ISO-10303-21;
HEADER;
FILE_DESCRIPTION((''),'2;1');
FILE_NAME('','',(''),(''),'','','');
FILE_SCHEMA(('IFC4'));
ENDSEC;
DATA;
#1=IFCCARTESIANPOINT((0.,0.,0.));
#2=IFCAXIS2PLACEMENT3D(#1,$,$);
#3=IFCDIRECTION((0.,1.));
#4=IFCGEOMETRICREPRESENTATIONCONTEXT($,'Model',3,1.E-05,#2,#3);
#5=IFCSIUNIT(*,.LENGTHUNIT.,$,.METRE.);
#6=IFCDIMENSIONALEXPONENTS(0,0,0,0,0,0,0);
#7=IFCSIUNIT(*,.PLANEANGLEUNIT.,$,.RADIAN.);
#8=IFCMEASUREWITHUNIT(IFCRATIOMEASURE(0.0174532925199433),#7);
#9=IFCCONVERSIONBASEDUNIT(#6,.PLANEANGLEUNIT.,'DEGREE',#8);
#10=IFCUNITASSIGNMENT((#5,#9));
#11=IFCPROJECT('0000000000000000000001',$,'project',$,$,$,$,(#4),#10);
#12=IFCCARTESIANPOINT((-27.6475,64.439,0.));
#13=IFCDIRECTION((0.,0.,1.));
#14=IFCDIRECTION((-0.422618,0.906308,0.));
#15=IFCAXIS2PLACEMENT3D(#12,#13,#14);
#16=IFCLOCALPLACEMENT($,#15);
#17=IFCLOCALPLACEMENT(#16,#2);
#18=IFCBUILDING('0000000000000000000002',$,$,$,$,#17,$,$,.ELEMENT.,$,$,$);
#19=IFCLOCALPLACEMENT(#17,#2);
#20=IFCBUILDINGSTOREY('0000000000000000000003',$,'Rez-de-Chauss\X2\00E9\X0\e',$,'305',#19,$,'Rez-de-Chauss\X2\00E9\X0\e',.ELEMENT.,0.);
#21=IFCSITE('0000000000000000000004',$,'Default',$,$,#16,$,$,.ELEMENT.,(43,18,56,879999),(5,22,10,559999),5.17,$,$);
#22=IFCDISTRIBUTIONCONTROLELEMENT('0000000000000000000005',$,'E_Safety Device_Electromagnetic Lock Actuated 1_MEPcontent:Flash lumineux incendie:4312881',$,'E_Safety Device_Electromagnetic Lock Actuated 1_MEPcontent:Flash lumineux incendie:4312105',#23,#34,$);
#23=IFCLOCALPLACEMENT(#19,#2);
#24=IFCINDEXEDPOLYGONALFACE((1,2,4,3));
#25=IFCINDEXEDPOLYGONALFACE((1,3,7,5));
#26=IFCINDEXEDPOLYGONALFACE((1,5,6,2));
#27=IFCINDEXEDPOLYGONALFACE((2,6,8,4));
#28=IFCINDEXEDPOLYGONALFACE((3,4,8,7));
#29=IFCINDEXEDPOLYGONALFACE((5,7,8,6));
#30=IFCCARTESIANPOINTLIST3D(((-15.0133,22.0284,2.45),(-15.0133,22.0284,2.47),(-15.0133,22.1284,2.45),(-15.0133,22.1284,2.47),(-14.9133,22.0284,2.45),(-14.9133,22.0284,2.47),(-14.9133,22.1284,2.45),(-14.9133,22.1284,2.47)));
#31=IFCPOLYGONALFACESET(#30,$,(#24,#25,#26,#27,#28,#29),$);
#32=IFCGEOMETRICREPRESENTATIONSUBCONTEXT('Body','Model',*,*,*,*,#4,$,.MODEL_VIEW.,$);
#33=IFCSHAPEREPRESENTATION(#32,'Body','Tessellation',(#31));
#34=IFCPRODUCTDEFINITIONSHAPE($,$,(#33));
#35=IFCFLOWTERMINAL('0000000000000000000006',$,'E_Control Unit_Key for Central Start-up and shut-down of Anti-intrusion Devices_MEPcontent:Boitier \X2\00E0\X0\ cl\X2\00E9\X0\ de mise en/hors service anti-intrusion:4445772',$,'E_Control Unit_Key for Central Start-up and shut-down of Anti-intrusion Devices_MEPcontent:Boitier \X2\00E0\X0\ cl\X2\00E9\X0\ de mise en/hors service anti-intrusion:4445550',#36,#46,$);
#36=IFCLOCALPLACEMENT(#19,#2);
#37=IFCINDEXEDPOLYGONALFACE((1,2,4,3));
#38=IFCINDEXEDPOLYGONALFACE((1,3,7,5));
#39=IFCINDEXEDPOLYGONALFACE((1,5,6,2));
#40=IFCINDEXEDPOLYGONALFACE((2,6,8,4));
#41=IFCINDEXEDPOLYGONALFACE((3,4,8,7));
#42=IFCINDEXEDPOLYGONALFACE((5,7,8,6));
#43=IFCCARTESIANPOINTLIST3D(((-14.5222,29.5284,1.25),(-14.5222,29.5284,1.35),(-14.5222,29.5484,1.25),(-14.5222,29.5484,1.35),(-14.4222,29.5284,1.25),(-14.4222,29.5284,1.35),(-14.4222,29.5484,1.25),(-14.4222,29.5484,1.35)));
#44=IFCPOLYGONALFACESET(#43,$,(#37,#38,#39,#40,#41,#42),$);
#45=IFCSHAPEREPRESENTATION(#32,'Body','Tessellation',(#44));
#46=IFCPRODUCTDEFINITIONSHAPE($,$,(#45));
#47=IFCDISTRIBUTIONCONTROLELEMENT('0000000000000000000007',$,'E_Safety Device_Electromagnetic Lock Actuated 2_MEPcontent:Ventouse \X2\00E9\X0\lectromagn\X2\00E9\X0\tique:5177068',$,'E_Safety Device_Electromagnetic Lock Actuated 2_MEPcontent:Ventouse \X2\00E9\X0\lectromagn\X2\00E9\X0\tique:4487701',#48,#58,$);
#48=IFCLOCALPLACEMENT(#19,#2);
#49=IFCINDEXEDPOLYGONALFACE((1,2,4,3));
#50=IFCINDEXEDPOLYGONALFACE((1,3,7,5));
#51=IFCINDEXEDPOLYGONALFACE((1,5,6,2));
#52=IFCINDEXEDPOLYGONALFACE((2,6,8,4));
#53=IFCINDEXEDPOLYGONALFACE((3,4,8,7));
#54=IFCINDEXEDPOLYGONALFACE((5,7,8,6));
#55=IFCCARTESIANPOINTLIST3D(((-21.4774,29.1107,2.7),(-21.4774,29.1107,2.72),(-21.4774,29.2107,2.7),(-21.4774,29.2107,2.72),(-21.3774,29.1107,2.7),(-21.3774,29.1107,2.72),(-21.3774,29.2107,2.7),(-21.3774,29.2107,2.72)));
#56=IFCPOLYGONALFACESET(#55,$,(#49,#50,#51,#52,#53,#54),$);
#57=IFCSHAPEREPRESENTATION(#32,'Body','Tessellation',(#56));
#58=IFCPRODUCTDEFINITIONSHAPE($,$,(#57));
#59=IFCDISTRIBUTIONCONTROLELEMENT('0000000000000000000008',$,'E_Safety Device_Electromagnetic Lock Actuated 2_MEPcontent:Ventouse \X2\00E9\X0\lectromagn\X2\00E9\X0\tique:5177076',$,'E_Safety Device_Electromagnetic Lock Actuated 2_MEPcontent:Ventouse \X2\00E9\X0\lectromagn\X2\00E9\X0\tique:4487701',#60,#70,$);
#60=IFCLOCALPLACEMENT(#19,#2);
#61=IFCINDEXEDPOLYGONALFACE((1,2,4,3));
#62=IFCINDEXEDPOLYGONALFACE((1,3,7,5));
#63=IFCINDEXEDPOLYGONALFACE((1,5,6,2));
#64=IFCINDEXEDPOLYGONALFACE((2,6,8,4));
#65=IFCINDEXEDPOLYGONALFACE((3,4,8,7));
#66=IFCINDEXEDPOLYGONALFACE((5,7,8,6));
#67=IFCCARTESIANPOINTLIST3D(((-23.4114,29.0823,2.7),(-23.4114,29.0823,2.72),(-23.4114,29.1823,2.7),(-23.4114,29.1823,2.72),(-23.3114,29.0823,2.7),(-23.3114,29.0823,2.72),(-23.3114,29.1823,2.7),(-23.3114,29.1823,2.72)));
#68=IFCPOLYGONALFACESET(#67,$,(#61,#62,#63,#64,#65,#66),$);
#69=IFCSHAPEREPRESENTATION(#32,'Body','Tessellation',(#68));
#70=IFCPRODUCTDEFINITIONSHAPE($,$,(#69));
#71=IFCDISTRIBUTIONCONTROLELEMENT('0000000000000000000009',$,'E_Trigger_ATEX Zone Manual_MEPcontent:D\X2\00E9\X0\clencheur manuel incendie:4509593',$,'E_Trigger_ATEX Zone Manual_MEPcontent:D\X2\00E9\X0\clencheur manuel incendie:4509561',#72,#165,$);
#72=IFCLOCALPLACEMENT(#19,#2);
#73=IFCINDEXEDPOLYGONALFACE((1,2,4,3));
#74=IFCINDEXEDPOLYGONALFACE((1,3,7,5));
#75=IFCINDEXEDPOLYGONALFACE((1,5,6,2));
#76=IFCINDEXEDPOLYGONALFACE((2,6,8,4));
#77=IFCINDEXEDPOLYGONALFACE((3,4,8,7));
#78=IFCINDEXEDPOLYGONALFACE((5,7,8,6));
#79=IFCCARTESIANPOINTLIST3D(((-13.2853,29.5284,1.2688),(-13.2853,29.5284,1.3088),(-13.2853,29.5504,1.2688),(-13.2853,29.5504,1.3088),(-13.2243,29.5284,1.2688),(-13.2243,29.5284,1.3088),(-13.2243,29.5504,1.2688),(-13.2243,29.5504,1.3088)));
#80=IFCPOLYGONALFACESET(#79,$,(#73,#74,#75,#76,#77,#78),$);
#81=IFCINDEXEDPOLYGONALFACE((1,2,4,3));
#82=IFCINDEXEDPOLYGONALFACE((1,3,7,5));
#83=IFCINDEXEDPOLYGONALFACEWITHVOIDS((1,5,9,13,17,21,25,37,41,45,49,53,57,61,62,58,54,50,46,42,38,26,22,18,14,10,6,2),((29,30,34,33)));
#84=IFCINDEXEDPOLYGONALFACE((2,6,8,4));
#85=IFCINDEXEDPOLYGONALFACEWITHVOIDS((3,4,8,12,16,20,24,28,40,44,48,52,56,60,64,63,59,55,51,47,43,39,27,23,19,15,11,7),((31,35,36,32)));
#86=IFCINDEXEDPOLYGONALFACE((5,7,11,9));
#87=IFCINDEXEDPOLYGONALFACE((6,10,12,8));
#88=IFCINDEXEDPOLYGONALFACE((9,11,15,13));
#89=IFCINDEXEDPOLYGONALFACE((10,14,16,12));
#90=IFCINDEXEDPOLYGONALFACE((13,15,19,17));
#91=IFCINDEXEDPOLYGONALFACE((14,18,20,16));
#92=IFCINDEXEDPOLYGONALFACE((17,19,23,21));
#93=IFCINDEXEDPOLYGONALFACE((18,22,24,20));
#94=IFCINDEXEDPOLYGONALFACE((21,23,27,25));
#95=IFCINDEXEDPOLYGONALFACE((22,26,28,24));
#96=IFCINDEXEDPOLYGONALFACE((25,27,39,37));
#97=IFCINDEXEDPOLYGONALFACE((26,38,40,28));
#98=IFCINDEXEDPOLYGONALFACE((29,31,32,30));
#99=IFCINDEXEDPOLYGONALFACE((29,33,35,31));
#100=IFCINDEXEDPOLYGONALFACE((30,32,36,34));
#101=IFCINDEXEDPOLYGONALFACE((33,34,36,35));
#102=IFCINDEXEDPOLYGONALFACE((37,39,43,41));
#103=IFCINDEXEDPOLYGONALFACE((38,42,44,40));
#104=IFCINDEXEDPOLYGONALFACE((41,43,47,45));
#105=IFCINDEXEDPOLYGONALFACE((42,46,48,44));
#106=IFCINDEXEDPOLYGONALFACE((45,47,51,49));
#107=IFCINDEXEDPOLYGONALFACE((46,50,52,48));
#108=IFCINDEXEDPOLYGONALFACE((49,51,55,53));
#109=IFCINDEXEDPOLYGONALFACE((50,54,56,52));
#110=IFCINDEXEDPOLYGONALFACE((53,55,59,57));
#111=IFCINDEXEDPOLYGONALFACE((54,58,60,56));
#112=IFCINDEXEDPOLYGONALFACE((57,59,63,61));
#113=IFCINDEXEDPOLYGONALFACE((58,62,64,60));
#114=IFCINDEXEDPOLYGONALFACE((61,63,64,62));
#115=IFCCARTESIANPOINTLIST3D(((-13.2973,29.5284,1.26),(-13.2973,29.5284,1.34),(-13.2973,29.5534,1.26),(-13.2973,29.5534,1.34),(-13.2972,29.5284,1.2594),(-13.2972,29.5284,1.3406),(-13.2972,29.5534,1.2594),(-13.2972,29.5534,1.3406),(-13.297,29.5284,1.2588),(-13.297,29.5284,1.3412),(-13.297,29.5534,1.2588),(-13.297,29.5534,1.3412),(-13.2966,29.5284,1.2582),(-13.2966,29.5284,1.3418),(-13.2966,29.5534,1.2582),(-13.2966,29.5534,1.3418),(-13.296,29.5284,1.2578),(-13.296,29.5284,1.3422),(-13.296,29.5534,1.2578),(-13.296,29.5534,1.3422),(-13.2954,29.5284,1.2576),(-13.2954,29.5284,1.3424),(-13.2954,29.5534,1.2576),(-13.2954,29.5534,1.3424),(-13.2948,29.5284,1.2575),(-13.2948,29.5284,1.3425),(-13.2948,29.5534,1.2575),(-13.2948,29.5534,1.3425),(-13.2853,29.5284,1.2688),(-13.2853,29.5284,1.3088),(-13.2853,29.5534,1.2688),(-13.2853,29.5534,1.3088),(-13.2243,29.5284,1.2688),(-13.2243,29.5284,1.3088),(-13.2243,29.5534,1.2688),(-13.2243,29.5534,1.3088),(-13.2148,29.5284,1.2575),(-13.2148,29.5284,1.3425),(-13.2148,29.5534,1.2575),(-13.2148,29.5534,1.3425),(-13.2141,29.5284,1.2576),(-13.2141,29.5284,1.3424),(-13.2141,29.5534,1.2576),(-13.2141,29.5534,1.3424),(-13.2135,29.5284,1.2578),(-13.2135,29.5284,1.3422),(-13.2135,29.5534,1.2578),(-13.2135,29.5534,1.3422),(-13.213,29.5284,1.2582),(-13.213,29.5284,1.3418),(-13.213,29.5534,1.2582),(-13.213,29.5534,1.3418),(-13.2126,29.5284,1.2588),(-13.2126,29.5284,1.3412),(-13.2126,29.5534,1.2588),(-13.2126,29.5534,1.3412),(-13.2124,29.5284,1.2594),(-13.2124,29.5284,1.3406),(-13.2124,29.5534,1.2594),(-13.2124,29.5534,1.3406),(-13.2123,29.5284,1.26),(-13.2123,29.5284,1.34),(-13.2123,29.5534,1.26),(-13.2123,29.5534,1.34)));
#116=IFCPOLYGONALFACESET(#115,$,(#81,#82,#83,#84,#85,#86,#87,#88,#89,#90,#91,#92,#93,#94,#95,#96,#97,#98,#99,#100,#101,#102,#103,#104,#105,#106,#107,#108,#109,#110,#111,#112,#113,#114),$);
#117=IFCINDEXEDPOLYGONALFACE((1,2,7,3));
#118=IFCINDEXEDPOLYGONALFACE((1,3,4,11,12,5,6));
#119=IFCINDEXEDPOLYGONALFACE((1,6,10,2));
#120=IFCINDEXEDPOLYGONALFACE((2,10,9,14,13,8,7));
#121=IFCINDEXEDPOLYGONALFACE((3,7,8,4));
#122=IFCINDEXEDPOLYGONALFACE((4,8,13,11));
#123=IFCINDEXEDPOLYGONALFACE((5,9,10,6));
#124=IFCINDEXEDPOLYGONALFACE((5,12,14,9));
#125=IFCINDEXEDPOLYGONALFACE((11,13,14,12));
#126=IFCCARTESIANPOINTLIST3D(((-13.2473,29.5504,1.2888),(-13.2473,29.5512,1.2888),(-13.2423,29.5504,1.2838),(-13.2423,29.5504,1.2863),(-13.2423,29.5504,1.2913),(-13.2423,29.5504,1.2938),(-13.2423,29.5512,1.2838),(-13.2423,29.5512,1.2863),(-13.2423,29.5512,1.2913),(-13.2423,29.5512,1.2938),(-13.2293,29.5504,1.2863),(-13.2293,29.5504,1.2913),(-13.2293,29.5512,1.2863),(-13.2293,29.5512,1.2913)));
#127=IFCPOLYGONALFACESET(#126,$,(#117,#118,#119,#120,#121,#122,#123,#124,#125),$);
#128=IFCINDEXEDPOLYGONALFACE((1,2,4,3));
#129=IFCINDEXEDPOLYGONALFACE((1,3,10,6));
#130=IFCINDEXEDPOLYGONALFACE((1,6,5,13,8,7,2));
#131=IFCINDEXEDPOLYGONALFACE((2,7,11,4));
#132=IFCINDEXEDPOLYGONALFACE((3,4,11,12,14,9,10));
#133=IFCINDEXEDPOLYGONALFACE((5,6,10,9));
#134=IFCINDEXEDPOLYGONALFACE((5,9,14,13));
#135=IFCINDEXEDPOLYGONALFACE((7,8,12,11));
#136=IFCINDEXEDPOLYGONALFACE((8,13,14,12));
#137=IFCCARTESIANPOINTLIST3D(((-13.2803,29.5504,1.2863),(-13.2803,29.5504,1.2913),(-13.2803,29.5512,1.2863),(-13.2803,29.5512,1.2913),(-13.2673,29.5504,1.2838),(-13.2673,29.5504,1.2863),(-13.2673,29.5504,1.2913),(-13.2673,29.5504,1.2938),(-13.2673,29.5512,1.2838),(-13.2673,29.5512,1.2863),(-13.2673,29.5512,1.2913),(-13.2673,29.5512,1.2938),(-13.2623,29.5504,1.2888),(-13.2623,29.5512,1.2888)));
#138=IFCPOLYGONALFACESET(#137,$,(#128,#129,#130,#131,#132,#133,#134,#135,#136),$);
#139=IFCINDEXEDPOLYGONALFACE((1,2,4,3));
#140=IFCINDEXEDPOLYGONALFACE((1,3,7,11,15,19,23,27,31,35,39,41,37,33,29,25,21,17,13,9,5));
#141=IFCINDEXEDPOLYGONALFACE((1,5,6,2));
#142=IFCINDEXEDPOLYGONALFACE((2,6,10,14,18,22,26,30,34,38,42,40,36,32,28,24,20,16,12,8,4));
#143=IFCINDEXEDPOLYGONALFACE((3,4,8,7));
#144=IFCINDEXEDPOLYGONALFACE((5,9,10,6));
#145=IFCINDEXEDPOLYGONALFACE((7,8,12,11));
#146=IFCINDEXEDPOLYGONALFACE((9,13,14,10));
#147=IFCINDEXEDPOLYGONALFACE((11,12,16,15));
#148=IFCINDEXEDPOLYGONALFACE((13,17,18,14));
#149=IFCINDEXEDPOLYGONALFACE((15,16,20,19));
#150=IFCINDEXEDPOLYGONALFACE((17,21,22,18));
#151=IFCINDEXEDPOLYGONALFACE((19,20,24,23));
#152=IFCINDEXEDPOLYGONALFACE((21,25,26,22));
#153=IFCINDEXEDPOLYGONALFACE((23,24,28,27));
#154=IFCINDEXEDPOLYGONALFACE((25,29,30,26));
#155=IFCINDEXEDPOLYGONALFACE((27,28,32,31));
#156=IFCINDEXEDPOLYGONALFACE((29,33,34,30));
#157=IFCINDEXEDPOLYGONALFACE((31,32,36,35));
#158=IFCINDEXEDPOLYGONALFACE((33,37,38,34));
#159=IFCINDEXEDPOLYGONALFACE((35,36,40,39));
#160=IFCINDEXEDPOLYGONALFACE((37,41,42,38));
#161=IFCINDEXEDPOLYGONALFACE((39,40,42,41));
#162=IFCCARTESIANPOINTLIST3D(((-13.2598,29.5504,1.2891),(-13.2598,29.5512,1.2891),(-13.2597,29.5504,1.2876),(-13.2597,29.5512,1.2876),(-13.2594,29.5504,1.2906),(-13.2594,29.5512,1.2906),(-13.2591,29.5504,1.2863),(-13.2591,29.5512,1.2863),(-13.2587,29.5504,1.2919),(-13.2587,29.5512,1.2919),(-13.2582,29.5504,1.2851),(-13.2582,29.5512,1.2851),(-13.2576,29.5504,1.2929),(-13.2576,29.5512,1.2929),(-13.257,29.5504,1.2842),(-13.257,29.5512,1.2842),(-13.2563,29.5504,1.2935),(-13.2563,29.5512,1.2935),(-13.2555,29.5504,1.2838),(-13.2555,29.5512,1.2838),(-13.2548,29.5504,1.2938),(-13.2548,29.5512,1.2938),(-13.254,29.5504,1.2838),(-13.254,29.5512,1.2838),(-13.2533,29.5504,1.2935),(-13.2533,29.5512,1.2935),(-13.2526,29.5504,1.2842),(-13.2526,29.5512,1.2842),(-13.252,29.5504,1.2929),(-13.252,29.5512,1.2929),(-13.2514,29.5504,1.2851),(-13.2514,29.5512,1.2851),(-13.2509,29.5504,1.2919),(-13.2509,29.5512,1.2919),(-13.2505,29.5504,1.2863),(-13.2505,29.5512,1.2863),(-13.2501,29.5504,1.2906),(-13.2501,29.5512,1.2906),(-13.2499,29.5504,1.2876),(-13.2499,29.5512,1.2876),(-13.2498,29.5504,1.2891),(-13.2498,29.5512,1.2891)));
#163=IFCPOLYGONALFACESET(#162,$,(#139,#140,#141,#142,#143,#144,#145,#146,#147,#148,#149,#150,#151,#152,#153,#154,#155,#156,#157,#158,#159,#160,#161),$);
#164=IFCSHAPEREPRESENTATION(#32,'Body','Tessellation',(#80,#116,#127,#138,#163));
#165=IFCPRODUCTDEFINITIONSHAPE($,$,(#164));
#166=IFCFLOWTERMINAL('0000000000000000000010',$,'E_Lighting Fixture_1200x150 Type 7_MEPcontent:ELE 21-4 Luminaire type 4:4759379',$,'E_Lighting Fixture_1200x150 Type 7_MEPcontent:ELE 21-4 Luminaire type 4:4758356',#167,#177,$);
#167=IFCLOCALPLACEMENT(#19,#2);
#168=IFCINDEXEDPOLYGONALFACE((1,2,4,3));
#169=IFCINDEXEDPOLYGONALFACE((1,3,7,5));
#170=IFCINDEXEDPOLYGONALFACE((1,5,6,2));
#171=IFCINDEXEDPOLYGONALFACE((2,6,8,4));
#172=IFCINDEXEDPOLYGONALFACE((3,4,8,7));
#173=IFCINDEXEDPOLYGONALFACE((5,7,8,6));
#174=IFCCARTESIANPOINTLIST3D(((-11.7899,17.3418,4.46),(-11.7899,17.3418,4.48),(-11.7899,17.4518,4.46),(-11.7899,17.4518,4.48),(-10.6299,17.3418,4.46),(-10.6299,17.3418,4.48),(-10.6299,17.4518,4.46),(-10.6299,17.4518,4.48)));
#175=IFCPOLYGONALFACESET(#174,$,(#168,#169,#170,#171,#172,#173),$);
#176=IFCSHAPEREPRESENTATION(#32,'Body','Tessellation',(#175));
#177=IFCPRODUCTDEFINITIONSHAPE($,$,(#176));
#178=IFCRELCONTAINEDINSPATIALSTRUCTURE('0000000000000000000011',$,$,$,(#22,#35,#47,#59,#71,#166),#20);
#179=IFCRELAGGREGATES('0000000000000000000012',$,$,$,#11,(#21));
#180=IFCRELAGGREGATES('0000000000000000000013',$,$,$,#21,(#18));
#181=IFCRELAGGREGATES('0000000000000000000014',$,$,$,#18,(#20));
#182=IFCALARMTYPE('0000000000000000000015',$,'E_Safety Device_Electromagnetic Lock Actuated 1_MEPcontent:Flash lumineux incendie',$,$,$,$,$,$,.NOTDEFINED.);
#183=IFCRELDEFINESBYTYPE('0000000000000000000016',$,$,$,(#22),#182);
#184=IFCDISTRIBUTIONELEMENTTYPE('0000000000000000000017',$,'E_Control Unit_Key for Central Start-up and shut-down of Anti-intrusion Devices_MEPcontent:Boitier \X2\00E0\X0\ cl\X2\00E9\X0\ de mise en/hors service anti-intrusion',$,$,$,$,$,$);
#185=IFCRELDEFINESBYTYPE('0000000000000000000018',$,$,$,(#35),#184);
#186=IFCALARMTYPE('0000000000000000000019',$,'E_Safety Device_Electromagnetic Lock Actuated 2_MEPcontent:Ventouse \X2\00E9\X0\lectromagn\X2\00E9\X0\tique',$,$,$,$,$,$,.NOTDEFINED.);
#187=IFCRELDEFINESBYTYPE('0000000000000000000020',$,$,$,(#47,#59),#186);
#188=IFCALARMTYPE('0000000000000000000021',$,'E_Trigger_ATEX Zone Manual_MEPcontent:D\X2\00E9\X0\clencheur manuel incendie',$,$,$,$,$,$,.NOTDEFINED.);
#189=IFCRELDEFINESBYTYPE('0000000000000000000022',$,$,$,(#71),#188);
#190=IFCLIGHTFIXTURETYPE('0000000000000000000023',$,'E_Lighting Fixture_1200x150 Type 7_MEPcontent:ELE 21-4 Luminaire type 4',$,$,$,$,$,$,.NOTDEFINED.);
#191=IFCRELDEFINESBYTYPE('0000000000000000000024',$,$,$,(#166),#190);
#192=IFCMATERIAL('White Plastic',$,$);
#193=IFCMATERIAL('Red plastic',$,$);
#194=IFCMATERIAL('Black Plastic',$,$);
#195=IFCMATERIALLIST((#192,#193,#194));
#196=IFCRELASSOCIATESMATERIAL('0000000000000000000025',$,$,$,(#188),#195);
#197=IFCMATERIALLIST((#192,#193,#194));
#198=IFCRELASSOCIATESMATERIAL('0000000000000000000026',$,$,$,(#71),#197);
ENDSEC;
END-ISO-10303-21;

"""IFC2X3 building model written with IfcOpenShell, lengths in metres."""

from ifc_helpers import new_model, entity, si_unit, converted_unit, direction, frame, frame_2d, origin, origin_2d_with_axis, place, context, subcontext, project, spatial, polyline, circle_curve, parameter, trimmed, segment, composite_curve, rectangle, circle, outline, extrude, source, transform, mapped, material, material_list, type_object, type_shapes, element, save


model = new_model("IFC2X3")

# Units and contexts
model_context = context("Model", 3, precision=1e-05, world=origin(), true_north=direction((0.0, 1.0)))
body_context = subcontext(model_context, "Body", "Model", "MODEL_VIEW")
ifc_project = project(units=[si_unit("LENGTHUNIT", "METRE"), converted_unit("PLANEANGLEUNIT", "DEGREE", entity("IfcRatioMeasure", 0.0174532925199433), si_unit("PLANEANGLEUNIT", "RADIAN"), dimensions=[0, 0, 0, 0, 0, 0, 0])], contexts=[model_context])

# Site, building, storey
site_placement = place(None, frame((-27.6475, 64.439, 0.0), z_axis=(0.0, 0.0, 1.0), x_axis=(-0.422618, 0.906308, 0.0)))
site = spatial("IfcSite", under=ifc_project, at=site_placement, Name="Default", CompositionType="ELEMENT", RefLatitude=(43, 18, 56, 879999), RefLongitude=(5, 22, 10, 559999), RefElevation=5.17)
building_placement = place(site_placement, origin())
building = spatial("IfcBuilding", under=site, at=building_placement, CompositionType="ELEMENT")
storey_placement = place(building_placement, origin())
storey = spatial("IfcBuildingStorey", under=building, at=storey_placement, Name="Rez-de-Chaussée", ObjectType="305", LongName="Rez-de-Chaussée", CompositionType="ELEMENT", Elevation=0.0)

# Distribution control element
alarm_type_1 = type_object("IfcAlarmType", Name="E_Safety Device_Electromagnetic Lock Actuated 1_MEPcontent:Flash lumineux incendie", PredefinedType="NOTDEFINED")
shared_shape_1 = source(origin(), body_context, "Body", "SweptSolid", [
    extrude(rectangle(XDim=0.1, YDim=0.1, at=origin_2d_with_axis()), frame((0.0, 0.0, 0.0), z_axis=(0.0, 0.0, 1.0), x_axis=(0.0, -1.0, 0.0)), (0.0, 0.0, 1.0), 0.02),
])
type_shapes(alarm_type_1, [shared_shape_1])
distribution_control_element_1_placement = place(storey_placement, frame((-14.9633, 22.0784, 2.45), z_axis=(0.0, 0.0, 1.0), x_axis=(0.0, -1.0, 0.0)))
element("IfcDistributionControlElement", 1, at=distribution_control_element_1_placement, inside=storey, type_object=alarm_type_1, Name="E_Safety Device_Electromagnetic Lock Actuated 1_MEPcontent:Flash lumineux incendie:4312881", ObjectType="E_Safety Device_Electromagnetic Lock Actuated 1_MEPcontent:Flash lumineux incendie:4312105", context=body_context, shape_type="MappedRepresentation", body=[
    mapped(shared_shape_1, transform((0.0, 0.0, 0.0), scale=1.0)),
])

# Flow terminal
distribution_element_type_1 = type_object("IfcDistributionElementType", Name="E_Control Unit_Key for Central Start-up and shut-down of Anti-intrusion Devices_MEPcontent:Boitier à clé de mise en/hors service anti-intrusion")
shared_shape_2 = source(origin(), body_context, "Body", "SweptSolid", [
    extrude(rectangle(XDim=0.02, YDim=0.1, at=frame_2d((0.0, 0.0), x_axis=(1.0, 0.0))), frame((0.0, -0.01, -0.05), z_axis=(0.0, 0.0, 1.0), x_axis=(0.0, 1.0, 0.0)), (0.0, 0.0, 1.0), 0.1),
])
type_shapes(distribution_element_type_1, [shared_shape_2])
flow_terminal_1_placement = place(storey_placement, frame((-14.4722, 29.5284, 1.3), z_axis=(0.0, 0.0, 1.0), x_axis=(-1.0, 0.0, 0.0)))
element("IfcFlowTerminal", 2, at=flow_terminal_1_placement, inside=storey, type_object=distribution_element_type_1, Name="E_Control Unit_Key for Central Start-up and shut-down of Anti-intrusion Devices_MEPcontent:Boitier à clé de mise en/hors service anti-intrusion:4445772", ObjectType="E_Control Unit_Key for Central Start-up and shut-down of Anti-intrusion Devices_MEPcontent:Boitier à clé de mise en/hors service anti-intrusion:4445550", context=body_context, shape_type="MappedRepresentation", body=[
    mapped(shared_shape_2, transform((0.0, 0.0, 0.0), scale=1.0)),
])

# Distribution control elements
alarm_type_2 = type_object("IfcAlarmType", Name="E_Safety Device_Electromagnetic Lock Actuated 2_MEPcontent:Ventouse électromagnétique", PredefinedType="NOTDEFINED")
shared_shape_3 = source(origin(), body_context, "Body", "SweptSolid", [
    extrude(rectangle(XDim=0.1, YDim=0.1, at=origin_2d_with_axis()), frame((0.0, 0.0, 0.0), z_axis=(0.0, 0.0, 1.0), x_axis=(0.0, -1.0, 0.0)), (0.0, 0.0, 1.0), 0.02),
])
type_shapes(alarm_type_2, [shared_shape_3])
for number, where, z_axis, x_axis, name in (
    (3, (-21.4274, 29.1607, 2.7), (0.0, 0.0, 1.0), (-1.0, 0.0, 0.0), "E_Safety Device_Electromagnetic Lock Actuated 2_MEPcontent:Ventouse électromagnétique:5177068"),
    (4, (-23.3614, 29.1323, 2.7), (0.0, 0.0, 1.0), (0.0, -1.0, 0.0), "E_Safety Device_Electromagnetic Lock Actuated 2_MEPcontent:Ventouse électromagnétique:5177076"),
):
    element("IfcDistributionControlElement", number, at=place(storey_placement, frame(where, z_axis=z_axis, x_axis=x_axis)), inside=storey, type_object=alarm_type_2, Name=name, ObjectType="E_Safety Device_Electromagnetic Lock Actuated 2_MEPcontent:Ventouse électromagnétique:4487701", context=body_context, shape_type="MappedRepresentation", body=[
        mapped(shared_shape_3, transform((0.0, 0.0, 0.0), scale=1.0)),
    ])
ifc_material_1 = material(Name="White Plastic")
ifc_material_2 = material(Name="Red plastic")
ifc_material_3 = material(Name="Black Plastic")
ifc_material_list_1 = material_list([ifc_material_1, ifc_material_2, ifc_material_3])
ifc_material_list_2 = material_list([ifc_material_1, ifc_material_2, ifc_material_3])
alarm_type_3 = type_object("IfcAlarmType", Name="E_Trigger_ATEX Zone Manual_MEPcontent:Déclencheur manuel incendie", PredefinedType="NOTDEFINED", material=ifc_material_list_2)
shared_shape_4 = source(origin(), body_context, "Body", "SweptSolid", [
    extrude(rectangle(XDim=0.022, YDim=0.061, at=frame_2d((0.0, 0.0), x_axis=(1.0, 0.0))), frame((0.0, 0.011, -0.0312), z_axis=(0.0, 0.0, 1.0), x_axis=(0.0, -1.0, 0.0)), (0.0, 0.0, 1.0), 0.04),
    extrude(outline(composite_curve([segment(polyline([(-0.04, -0.0425), (0.04, -0.0425)]), True, "CONTINUOUS"), segment(trimmed(circle_curve(frame_2d((0.04, -0.04), x_axis=(-1.0, 0.0)), 0.0025), [parameter(90.0)], [parameter(180.0)], True, "PARAMETER"), True, "CONTINUOUS"), segment(polyline([(0.0425, -0.04), (0.0425, 0.04)]), True, "CONTINUOUS"), segment(trimmed(circle_curve(frame_2d((0.04, 0.04), x_axis=(-1.0, 0.0)), 0.0025), [parameter(180.0)], [parameter(270.0)], True, "PARAMETER"), True, "CONTINUOUS"), segment(polyline([(0.04, 0.0425), (-0.04, 0.0425)]), True, "CONTINUOUS"), segment(trimmed(circle_curve(frame_2d((-0.04, 0.04), x_axis=(-1.0, 0.0)), 0.0025), [parameter(270.0)], [parameter(0.0)], True, "PARAMETER"), True, "CONTINUOUS"), segment(polyline([(-0.0425, 0.04), (-0.0425, -0.04)]), True, "CONTINUOUS"), segment(trimmed(circle_curve(frame_2d((-0.04, -0.04), x_axis=(-1.0, 0.0)), 0.0025), [parameter(360.0)], [parameter(90.0)], True, "PARAMETER"), True, "CONTINUOUS")], self_intersect=False), holes=[polyline([(-0.0305, -0.0088), (-0.0305, 0.0312), (0.0305, 0.0312), (0.0305, -0.0088), (-0.0305, -0.0088)])]), frame((0.0, 0.0, 0.0), z_axis=(0.0, 1.0, 0.0), x_axis=(1.0, 0.0, 0.0)), (0.0, 0.0, 1.0), 0.025),
    extrude(outline(polyline([(-0.01, 0.0025), (-0.01, -0.0025), (0.003, -0.0025), (0.003, -0.005), (0.008, 0.0), (0.003, 0.005), (0.003, 0.0025), (-0.01, 0.0025)])), frame((0.0155, 0.022, -0.0112), z_axis=(0.0, -1.0, 0.0), x_axis=(-1.0, 0.0, 0.0)), (0.0, 0.0, -1.0), 0.0008),
    extrude(outline(polyline([(-0.0014, -0.0057), (0.0057, -0.0057), (0.0057, 0.0014), (0.0039, -0.0004), (-0.0053, 0.0088), (-0.0088, 0.0053), (0.0004, -0.0039), (-0.0014, -0.0057)])), frame((-0.0155, 0.022, -0.0112), z_axis=(0.0, 1.0, 0.0), x_axis=(0.707107, 0.0, -0.707107)), (0.0, 0.0, 1.0), 0.0008),
    extrude(circle(Radius=0.005, at=frame_2d((0.0, 0.0), x_axis=(1.0, 0.0))), frame((0.0, 0.022, -0.0112), z_axis=(0.0, 1.0, 0.0), x_axis=(0.0, 0.0, 1.0)), (0.0, 0.0, 1.0), 0.0008),
])
type_shapes(alarm_type_3, [shared_shape_4])
distribution_control_element_2_placement = place(storey_placement, frame((-13.2548, 29.5284, 1.3)))
element("IfcDistributionControlElement", 5, at=distribution_control_element_2_placement, inside=storey, type_object=alarm_type_3, material=ifc_material_list_1, Name="E_Trigger_ATEX Zone Manual_MEPcontent:Déclencheur manuel incendie:4509593", ObjectType="E_Trigger_ATEX Zone Manual_MEPcontent:Déclencheur manuel incendie:4509561", context=body_context, shape_type="MappedRepresentation", body=[
    mapped(shared_shape_4, transform((0.0, 0.0, 0.0), scale=1.0)),
])

# Flow terminal
light_fixture_type_1 = type_object("IfcLightFixtureType", Name="E_Lighting Fixture_1200x150 Type 7_MEPcontent:ELE 21-4 Luminaire type 4", PredefinedType="NOTDEFINED")
shared_shape_5 = source(origin(), body_context, "Body", "SweptSolid", [
    extrude(rectangle(XDim=0.11, YDim=1.16, at=origin_2d_with_axis()), frame((0.0, 0.0, 0.0), z_axis=(0.0, 0.0, 1.0), x_axis=(0.0, -1.0, 0.0)), (0.0, 0.0, 1.0), 0.02),
])
type_shapes(light_fixture_type_1, [shared_shape_5])
for number, where, name in (
    (6, (-11.2099, 17.3968, 4.46), "E_Lighting Fixture_1200x150 Type 7_MEPcontent:ELE 21-4 Luminaire type 4:4759379"),
):
    element("IfcFlowTerminal", number, at=place(storey_placement, frame(where)), inside=storey, type_object=light_fixture_type_1, Name=name, ObjectType="E_Lighting Fixture_1200x150 Type 7_MEPcontent:ELE 21-4 Luminaire type 4:4758356", context=body_context, shape_type="MappedRepresentation", body=[
        mapped(shared_shape_5, transform((0.0, 0.0, 0.0), scale=1.0)),
    ])

save(model, "model.ifc")
